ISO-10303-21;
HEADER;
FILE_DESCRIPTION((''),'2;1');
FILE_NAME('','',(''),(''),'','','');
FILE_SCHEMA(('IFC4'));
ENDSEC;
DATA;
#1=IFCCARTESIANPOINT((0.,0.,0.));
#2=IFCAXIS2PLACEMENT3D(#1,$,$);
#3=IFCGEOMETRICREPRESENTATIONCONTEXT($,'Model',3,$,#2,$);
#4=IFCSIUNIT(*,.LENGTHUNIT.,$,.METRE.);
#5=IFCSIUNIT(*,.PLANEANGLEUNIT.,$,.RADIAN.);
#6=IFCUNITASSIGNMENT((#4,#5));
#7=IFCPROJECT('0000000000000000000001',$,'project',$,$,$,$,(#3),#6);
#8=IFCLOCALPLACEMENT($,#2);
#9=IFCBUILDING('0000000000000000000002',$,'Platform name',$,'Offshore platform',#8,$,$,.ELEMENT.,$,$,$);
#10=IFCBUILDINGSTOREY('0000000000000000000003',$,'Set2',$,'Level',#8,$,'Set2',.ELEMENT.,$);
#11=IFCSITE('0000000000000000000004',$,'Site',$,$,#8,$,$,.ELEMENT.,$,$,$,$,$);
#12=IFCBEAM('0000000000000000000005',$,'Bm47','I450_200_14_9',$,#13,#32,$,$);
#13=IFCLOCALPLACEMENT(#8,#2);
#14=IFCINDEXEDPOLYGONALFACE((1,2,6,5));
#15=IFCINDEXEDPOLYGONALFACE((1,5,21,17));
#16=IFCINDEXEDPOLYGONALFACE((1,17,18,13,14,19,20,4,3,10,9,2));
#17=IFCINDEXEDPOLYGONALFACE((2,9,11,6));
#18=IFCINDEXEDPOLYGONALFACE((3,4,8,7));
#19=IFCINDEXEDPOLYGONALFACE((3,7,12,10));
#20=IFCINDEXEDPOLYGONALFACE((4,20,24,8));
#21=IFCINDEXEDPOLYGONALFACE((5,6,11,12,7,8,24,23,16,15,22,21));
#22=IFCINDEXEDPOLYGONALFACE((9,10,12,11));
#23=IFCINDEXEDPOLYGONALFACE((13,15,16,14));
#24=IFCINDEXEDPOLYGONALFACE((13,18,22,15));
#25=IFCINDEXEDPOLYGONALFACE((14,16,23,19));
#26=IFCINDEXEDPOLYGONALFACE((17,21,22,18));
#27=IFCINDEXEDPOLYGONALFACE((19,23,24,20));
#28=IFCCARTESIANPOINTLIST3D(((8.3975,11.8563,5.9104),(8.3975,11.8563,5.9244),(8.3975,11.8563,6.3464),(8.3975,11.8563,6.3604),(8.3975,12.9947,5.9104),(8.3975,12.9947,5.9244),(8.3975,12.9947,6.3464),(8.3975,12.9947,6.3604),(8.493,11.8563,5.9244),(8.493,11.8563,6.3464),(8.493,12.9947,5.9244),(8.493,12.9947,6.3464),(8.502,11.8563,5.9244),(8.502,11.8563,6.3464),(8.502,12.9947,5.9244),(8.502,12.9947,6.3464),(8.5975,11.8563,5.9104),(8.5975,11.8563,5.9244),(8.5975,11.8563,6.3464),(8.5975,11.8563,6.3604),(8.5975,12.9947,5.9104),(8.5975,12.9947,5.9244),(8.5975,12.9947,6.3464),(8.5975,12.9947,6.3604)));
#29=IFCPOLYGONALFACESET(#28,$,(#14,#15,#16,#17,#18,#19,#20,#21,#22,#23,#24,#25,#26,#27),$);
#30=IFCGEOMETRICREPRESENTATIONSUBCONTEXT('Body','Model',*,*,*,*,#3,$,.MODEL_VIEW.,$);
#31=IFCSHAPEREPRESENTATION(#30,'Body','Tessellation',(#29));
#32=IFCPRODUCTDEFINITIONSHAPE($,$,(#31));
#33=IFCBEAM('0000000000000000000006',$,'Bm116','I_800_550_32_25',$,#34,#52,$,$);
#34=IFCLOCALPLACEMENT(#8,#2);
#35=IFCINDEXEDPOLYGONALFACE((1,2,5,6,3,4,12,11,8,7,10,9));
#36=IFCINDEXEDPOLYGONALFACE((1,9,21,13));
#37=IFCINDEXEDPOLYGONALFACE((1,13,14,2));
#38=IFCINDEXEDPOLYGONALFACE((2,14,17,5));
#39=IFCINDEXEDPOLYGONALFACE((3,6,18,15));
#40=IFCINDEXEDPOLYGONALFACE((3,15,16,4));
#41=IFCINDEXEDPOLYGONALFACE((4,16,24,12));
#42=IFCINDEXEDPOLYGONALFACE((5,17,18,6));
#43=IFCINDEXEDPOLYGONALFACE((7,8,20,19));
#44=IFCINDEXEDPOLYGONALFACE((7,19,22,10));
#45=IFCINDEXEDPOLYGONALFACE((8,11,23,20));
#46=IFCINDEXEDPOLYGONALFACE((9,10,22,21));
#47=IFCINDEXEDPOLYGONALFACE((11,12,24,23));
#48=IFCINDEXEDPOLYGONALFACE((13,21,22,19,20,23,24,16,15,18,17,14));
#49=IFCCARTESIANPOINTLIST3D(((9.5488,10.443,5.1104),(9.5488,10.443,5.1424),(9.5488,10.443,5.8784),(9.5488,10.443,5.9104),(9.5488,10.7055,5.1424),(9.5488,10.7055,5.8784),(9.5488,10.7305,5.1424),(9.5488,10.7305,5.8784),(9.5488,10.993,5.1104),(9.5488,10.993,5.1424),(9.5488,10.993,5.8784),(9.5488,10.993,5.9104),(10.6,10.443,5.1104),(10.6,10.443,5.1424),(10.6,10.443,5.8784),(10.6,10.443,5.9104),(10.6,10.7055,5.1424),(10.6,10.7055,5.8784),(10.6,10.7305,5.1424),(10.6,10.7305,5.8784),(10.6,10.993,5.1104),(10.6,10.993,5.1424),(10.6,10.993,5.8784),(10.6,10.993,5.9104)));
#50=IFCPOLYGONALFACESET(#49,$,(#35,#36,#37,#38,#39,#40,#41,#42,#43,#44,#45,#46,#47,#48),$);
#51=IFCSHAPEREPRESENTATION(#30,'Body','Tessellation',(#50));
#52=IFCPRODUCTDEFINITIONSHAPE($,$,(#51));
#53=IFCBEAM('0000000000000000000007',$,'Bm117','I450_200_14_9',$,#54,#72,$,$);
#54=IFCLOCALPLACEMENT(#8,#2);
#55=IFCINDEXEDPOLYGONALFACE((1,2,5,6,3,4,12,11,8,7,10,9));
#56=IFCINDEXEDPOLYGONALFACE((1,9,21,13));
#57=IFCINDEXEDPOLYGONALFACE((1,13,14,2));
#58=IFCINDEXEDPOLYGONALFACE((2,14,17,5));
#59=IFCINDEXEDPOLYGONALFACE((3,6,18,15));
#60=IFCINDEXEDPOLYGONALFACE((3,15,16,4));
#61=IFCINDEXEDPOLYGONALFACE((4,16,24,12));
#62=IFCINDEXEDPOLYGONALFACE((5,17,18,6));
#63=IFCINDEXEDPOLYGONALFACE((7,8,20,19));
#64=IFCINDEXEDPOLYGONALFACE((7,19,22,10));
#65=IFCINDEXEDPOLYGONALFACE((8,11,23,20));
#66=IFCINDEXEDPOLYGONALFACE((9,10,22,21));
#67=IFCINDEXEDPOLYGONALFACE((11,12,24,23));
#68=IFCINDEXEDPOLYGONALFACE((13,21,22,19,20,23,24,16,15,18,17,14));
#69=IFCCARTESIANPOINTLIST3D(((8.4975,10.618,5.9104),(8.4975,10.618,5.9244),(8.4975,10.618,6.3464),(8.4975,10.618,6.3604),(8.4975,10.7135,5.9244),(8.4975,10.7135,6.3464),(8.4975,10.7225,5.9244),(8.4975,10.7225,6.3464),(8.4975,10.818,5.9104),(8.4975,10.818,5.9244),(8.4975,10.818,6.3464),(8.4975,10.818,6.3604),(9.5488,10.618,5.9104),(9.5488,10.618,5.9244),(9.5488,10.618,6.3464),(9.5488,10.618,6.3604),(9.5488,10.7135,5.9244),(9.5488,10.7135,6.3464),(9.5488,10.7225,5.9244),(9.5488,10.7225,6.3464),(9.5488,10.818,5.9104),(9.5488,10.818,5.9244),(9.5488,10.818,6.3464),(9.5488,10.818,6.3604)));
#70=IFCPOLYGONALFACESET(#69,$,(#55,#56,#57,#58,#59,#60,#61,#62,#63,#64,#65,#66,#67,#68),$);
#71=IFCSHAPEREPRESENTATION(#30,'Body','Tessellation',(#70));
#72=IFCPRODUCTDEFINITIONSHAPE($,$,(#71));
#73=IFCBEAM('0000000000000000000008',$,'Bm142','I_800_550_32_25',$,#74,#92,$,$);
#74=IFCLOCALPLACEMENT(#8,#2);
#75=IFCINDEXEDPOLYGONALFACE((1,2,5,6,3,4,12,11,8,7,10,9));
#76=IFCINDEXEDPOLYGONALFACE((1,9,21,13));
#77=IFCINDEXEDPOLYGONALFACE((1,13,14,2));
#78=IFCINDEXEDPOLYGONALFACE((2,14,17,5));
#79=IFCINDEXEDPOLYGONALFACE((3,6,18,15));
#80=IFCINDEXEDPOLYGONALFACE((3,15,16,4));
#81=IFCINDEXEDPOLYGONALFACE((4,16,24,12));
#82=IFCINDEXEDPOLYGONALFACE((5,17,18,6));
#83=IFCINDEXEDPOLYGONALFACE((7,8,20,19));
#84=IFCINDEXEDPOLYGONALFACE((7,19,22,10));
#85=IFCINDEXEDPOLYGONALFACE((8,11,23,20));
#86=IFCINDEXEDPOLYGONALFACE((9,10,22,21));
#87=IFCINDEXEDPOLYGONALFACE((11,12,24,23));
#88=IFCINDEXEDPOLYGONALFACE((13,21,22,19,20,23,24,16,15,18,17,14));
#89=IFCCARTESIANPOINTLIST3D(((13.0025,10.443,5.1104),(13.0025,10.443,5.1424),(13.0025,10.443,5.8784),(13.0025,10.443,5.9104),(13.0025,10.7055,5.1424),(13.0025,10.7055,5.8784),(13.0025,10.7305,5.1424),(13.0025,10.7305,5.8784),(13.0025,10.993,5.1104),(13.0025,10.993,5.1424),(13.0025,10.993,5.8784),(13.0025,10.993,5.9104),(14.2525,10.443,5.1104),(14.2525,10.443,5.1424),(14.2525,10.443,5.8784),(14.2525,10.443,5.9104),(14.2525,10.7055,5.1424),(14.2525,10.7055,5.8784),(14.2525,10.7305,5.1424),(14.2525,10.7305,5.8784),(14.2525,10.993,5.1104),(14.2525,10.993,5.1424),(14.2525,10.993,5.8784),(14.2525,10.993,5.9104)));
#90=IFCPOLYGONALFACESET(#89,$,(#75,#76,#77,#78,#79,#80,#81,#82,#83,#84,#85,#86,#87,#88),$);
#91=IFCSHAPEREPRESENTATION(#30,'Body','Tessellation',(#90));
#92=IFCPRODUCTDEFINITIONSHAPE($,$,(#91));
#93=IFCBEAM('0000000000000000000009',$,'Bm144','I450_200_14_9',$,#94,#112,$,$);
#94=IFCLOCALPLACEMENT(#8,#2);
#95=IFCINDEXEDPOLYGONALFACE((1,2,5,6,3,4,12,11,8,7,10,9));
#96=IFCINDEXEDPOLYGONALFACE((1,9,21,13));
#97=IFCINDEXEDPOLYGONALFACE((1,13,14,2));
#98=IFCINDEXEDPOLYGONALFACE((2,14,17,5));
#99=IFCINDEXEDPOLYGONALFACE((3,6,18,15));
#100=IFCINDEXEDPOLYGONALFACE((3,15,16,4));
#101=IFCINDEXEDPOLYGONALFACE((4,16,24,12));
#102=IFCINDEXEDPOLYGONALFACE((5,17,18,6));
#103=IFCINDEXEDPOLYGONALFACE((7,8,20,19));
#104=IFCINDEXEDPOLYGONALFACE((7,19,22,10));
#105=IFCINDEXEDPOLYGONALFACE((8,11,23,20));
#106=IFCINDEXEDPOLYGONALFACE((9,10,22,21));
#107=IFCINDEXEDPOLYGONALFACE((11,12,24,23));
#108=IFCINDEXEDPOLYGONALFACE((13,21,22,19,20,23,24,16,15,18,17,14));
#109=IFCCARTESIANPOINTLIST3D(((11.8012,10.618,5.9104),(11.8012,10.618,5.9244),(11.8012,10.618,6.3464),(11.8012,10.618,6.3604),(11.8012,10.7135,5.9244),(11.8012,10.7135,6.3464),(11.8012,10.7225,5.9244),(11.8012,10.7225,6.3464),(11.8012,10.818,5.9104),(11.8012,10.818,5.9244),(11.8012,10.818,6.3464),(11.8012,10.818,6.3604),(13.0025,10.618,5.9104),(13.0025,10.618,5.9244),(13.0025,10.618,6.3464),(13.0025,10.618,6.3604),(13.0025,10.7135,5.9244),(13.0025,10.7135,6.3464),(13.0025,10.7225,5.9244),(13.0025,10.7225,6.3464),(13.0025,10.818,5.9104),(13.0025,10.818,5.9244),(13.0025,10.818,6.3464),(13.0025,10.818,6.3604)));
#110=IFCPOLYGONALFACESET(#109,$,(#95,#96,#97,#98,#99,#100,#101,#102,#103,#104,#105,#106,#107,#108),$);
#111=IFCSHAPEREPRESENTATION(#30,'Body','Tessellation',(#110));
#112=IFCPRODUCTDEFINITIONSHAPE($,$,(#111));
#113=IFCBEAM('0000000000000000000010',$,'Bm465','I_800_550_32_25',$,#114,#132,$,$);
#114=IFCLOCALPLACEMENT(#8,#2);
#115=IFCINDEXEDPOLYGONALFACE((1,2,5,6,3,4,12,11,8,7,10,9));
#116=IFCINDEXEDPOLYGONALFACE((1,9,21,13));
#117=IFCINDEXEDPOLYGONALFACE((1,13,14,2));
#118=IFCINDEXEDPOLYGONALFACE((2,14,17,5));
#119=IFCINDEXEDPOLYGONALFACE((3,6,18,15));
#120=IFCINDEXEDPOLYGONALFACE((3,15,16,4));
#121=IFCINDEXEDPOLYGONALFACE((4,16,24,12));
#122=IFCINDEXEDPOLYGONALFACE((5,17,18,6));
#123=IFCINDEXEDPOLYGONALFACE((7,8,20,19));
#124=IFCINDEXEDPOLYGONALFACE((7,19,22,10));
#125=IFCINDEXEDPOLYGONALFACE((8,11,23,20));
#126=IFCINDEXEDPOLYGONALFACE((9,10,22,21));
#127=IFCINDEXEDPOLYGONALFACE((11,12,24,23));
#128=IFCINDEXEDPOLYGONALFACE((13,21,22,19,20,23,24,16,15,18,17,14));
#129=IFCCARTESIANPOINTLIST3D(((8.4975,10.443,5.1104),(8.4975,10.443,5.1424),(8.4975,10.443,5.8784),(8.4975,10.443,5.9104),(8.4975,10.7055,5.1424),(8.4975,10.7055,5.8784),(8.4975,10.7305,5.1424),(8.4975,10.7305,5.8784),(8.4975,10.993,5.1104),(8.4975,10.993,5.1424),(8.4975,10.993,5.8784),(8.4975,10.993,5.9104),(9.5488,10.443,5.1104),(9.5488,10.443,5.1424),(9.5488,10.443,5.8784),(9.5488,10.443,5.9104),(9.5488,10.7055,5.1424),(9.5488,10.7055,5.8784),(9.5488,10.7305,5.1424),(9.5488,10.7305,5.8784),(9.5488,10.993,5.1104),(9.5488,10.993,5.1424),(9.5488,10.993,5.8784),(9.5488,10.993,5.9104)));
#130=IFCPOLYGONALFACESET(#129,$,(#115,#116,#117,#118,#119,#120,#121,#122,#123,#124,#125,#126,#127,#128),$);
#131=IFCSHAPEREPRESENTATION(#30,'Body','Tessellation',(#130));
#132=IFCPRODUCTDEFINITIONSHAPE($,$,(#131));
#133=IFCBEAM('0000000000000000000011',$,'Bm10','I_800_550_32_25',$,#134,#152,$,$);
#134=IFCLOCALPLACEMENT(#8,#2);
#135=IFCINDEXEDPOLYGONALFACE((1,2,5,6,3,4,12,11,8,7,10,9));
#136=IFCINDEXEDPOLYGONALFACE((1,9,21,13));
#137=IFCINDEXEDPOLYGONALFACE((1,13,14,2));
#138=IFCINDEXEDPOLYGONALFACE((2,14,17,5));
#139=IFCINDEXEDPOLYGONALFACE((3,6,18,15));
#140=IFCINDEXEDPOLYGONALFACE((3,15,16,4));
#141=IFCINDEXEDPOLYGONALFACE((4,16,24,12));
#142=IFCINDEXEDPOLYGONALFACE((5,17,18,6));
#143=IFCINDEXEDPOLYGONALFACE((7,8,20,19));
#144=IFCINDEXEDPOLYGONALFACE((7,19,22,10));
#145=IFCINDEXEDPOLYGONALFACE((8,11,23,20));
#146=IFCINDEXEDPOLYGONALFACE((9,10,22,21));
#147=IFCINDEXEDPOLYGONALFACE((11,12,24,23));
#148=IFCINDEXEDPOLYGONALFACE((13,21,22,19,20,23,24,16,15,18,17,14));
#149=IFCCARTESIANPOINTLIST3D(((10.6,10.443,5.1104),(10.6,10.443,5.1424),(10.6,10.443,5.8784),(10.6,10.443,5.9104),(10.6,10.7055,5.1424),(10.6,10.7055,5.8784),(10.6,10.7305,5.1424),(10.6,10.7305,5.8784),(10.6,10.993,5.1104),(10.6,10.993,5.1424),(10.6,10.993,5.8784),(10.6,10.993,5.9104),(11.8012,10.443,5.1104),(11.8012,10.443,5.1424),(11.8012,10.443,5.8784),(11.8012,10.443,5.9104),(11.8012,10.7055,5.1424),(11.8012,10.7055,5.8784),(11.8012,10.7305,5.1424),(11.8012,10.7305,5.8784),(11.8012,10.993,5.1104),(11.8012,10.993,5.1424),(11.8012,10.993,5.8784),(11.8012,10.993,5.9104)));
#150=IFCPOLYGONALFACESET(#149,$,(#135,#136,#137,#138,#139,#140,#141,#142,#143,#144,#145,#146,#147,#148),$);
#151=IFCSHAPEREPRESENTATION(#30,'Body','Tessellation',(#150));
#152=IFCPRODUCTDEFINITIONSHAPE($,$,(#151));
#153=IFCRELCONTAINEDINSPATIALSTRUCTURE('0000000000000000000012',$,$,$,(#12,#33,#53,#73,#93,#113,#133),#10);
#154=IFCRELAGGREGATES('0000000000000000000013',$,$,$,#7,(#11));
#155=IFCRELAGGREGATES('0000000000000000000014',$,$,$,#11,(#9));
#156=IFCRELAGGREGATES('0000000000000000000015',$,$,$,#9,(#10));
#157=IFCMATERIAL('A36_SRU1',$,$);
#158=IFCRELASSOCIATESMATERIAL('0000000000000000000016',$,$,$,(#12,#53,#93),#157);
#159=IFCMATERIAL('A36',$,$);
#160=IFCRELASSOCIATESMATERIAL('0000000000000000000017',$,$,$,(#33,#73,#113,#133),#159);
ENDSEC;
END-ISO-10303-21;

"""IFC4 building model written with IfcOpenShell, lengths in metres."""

from ifc_helpers import new_model, si_unit, frame, origin, origin_2d, place, context, subcontext, project, spatial, i_section, extrude, source, transform, mapped, material, element, save


model = new_model("IFC4")

# Units and contexts
model_context = context("Model", 3, world=origin())
body_context = subcontext(model_context, "Body", "Model", "MODEL_VIEW")
ifc_project = project(units=[si_unit("LENGTHUNIT", "METRE"), si_unit("PLANEANGLEUNIT", "RADIAN")], contexts=[model_context])

# Site, building, storey
placement_1 = place(None, origin())
site = spatial("IfcSite", under=ifc_project, at=placement_1, Name="Site", CompositionType="ELEMENT")
building = spatial("IfcBuilding", under=site, at=placement_1, Name="Platform name", ObjectType="Offshore platform", CompositionType="ELEMENT")
storey = spatial("IfcBuildingStorey", under=building, at=placement_1, Name="Set2", ObjectType="Level", LongName="Set2", CompositionType="ELEMENT")

# Beams
ifc_material_1 = material(Name="A36_SRU1")
ifc_material_2 = material(Name="A36")
shared_shape_1 = source(origin(), body_context, "Body", "SweptSolid", [
    extrude(i_section(OverallWidth=0.2, OverallDepth=0.45, WebThickness=0.009, FlangeThickness=0.014, FilletRadius=0.0, at=origin_2d()), frame((0.0, 0.0, 0.0), z_axis=(0.0, 1.0, 0.0), x_axis=(-1.0, 0.0, 0.0)), (0.0, 0.0, 1.0), 1.1383),
])
placement_2 = place(None, origin())
placement_3 = place(placement_2, origin())
placement_4 = place(placement_3, origin())
beam_1_placement = place(placement_4, frame((8.4975, 11.8563, 6.1354)))
element("IfcBeam", 1, at=beam_1_placement, inside=storey, material=ifc_material_1, Name="Bm47", Description="I450_200_14_9", context=body_context, shape_type="MappedRepresentation", body=[
    mapped(shared_shape_1, transform((0.0, 0.0, 0.0), scale=1.0)),
])
shared_shape_2 = source(origin(), body_context, "Body", "SweptSolid", [
    extrude(i_section(OverallWidth=0.55, OverallDepth=0.8, WebThickness=0.025, FlangeThickness=0.032, FilletRadius=0.0, at=origin_2d()), frame((0.0, 0.0, 0.0), z_axis=(1.0, 0.0, 0.0), x_axis=(0.0, 1.0, 0.0)), (0.0, 0.0, 1.0), 1.0513),
])
placement_5 = place(None, origin())
placement_6 = place(placement_5, origin())
placement_7 = place(placement_6, origin())
beam_2_placement = place(placement_7, frame((9.5488, 10.718, 5.5104)))
element("IfcBeam", 2, at=beam_2_placement, inside=storey, material=ifc_material_2, Name="Bm116", Description="I_800_550_32_25", context=body_context, shape_type="MappedRepresentation", body=[
    mapped(shared_shape_2, transform((0.0, 0.0, 0.0), scale=1.0)),
])
shared_shape_3 = source(origin(), body_context, "Body", "SweptSolid", [
    extrude(i_section(OverallWidth=0.2, OverallDepth=0.45, WebThickness=0.009, FlangeThickness=0.014, FilletRadius=0.0, at=origin_2d()), frame((0.0, 0.0, 0.0), z_axis=(-1.0, 0.0, 0.0), x_axis=(0.0, -1.0, 0.0)), (0.0, 0.0, 1.0), 1.0513),
])
placement_8 = place(None, origin())
placement_9 = place(placement_8, origin())
placement_10 = place(placement_9, origin())
beam_3_placement = place(placement_10, frame((9.5488, 10.718, 6.1354)))
element("IfcBeam", 3, at=beam_3_placement, inside=storey, material=ifc_material_1, Name="Bm117", Description="I450_200_14_9", context=body_context, shape_type="MappedRepresentation", body=[
    mapped(shared_shape_3, transform((0.0, 0.0, 0.0), scale=1.0)),
])
shared_shape_4 = source(origin(), body_context, "Body", "SweptSolid", [
    extrude(i_section(OverallWidth=0.55, OverallDepth=0.8, WebThickness=0.025, FlangeThickness=0.032, FilletRadius=0.0, at=origin_2d()), frame((0.0, 0.0, 0.0), z_axis=(1.0, 0.0, 0.0), x_axis=(0.0, 1.0, 0.0)), (0.0, 0.0, 1.0), 1.25),
])
placement_11 = place(None, origin())
placement_12 = place(placement_11, origin())
placement_13 = place(placement_12, origin())
beam_4_placement = place(placement_13, frame((13.0025, 10.718, 5.5104)))
element("IfcBeam", 4, at=beam_4_placement, inside=storey, material=ifc_material_2, Name="Bm142", Description="I_800_550_32_25", context=body_context, shape_type="MappedRepresentation", body=[
    mapped(shared_shape_4, transform((0.0, 0.0, 0.0), scale=1.0)),
])
shared_shape_5 = source(origin(), body_context, "Body", "SweptSolid", [
    extrude(i_section(OverallWidth=0.2, OverallDepth=0.45, WebThickness=0.009, FlangeThickness=0.014, FilletRadius=0.0, at=origin_2d()), frame((0.0, 0.0, 0.0), z_axis=(-1.0, 0.0, 0.0), x_axis=(0.0, -1.0, 0.0)), (0.0, 0.0, 1.0), 1.2012),
])
placement_14 = place(None, origin())
placement_15 = place(placement_14, origin())
placement_16 = place(placement_15, origin())
beam_5_placement = place(placement_16, frame((13.0025, 10.718, 6.1354)))
element("IfcBeam", 5, at=beam_5_placement, inside=storey, material=ifc_material_1, Name="Bm144", Description="I450_200_14_9", context=body_context, shape_type="MappedRepresentation", body=[
    mapped(shared_shape_5, transform((0.0, 0.0, 0.0), scale=1.0)),
])
shared_shape_6 = source(origin(), body_context, "Body", "SweptSolid", [
    extrude(i_section(OverallWidth=0.55, OverallDepth=0.8, WebThickness=0.025, FlangeThickness=0.032, FilletRadius=0.0, at=origin_2d()), frame((0.0, 0.0, 0.0), z_axis=(1.0, 0.0, 0.0), x_axis=(0.0, 1.0, 0.0)), (0.0, 0.0, 1.0), 1.0513),
])
placement_17 = place(None, origin())
placement_18 = place(placement_17, origin())
placement_19 = place(placement_18, origin())
beam_6_placement = place(placement_19, frame((8.4975, 10.718, 5.5104)))
element("IfcBeam", 6, at=beam_6_placement, inside=storey, material=ifc_material_2, Name="Bm465", Description="I_800_550_32_25", context=body_context, shape_type="MappedRepresentation", body=[
    mapped(shared_shape_6, transform((0.0, 0.0, 0.0), scale=1.0)),
])
shared_shape_7 = source(origin(), body_context, "Body", "SweptSolid", [
    extrude(i_section(OverallWidth=0.55, OverallDepth=0.8, WebThickness=0.025, FlangeThickness=0.032, FilletRadius=0.0, at=origin_2d()), frame((0.0, 0.0, 0.0), z_axis=(1.0, 0.0, 0.0), x_axis=(0.0, 1.0, 0.0)), (0.0, 0.0, 1.0), 1.2012),
])
placement_20 = place(None, origin())
placement_21 = place(placement_20, origin())
placement_22 = place(placement_21, origin())
beam_7_placement = place(placement_22, frame((10.6, 10.718, 5.5104)))
element("IfcBeam", 7, at=beam_7_placement, inside=storey, material=ifc_material_2, Name="Bm10", Description="I_800_550_32_25", context=body_context, shape_type="MappedRepresentation", body=[
    mapped(shared_shape_7, transform((0.0, 0.0, 0.0), scale=1.0)),
])

save(model, "model.ifc")
